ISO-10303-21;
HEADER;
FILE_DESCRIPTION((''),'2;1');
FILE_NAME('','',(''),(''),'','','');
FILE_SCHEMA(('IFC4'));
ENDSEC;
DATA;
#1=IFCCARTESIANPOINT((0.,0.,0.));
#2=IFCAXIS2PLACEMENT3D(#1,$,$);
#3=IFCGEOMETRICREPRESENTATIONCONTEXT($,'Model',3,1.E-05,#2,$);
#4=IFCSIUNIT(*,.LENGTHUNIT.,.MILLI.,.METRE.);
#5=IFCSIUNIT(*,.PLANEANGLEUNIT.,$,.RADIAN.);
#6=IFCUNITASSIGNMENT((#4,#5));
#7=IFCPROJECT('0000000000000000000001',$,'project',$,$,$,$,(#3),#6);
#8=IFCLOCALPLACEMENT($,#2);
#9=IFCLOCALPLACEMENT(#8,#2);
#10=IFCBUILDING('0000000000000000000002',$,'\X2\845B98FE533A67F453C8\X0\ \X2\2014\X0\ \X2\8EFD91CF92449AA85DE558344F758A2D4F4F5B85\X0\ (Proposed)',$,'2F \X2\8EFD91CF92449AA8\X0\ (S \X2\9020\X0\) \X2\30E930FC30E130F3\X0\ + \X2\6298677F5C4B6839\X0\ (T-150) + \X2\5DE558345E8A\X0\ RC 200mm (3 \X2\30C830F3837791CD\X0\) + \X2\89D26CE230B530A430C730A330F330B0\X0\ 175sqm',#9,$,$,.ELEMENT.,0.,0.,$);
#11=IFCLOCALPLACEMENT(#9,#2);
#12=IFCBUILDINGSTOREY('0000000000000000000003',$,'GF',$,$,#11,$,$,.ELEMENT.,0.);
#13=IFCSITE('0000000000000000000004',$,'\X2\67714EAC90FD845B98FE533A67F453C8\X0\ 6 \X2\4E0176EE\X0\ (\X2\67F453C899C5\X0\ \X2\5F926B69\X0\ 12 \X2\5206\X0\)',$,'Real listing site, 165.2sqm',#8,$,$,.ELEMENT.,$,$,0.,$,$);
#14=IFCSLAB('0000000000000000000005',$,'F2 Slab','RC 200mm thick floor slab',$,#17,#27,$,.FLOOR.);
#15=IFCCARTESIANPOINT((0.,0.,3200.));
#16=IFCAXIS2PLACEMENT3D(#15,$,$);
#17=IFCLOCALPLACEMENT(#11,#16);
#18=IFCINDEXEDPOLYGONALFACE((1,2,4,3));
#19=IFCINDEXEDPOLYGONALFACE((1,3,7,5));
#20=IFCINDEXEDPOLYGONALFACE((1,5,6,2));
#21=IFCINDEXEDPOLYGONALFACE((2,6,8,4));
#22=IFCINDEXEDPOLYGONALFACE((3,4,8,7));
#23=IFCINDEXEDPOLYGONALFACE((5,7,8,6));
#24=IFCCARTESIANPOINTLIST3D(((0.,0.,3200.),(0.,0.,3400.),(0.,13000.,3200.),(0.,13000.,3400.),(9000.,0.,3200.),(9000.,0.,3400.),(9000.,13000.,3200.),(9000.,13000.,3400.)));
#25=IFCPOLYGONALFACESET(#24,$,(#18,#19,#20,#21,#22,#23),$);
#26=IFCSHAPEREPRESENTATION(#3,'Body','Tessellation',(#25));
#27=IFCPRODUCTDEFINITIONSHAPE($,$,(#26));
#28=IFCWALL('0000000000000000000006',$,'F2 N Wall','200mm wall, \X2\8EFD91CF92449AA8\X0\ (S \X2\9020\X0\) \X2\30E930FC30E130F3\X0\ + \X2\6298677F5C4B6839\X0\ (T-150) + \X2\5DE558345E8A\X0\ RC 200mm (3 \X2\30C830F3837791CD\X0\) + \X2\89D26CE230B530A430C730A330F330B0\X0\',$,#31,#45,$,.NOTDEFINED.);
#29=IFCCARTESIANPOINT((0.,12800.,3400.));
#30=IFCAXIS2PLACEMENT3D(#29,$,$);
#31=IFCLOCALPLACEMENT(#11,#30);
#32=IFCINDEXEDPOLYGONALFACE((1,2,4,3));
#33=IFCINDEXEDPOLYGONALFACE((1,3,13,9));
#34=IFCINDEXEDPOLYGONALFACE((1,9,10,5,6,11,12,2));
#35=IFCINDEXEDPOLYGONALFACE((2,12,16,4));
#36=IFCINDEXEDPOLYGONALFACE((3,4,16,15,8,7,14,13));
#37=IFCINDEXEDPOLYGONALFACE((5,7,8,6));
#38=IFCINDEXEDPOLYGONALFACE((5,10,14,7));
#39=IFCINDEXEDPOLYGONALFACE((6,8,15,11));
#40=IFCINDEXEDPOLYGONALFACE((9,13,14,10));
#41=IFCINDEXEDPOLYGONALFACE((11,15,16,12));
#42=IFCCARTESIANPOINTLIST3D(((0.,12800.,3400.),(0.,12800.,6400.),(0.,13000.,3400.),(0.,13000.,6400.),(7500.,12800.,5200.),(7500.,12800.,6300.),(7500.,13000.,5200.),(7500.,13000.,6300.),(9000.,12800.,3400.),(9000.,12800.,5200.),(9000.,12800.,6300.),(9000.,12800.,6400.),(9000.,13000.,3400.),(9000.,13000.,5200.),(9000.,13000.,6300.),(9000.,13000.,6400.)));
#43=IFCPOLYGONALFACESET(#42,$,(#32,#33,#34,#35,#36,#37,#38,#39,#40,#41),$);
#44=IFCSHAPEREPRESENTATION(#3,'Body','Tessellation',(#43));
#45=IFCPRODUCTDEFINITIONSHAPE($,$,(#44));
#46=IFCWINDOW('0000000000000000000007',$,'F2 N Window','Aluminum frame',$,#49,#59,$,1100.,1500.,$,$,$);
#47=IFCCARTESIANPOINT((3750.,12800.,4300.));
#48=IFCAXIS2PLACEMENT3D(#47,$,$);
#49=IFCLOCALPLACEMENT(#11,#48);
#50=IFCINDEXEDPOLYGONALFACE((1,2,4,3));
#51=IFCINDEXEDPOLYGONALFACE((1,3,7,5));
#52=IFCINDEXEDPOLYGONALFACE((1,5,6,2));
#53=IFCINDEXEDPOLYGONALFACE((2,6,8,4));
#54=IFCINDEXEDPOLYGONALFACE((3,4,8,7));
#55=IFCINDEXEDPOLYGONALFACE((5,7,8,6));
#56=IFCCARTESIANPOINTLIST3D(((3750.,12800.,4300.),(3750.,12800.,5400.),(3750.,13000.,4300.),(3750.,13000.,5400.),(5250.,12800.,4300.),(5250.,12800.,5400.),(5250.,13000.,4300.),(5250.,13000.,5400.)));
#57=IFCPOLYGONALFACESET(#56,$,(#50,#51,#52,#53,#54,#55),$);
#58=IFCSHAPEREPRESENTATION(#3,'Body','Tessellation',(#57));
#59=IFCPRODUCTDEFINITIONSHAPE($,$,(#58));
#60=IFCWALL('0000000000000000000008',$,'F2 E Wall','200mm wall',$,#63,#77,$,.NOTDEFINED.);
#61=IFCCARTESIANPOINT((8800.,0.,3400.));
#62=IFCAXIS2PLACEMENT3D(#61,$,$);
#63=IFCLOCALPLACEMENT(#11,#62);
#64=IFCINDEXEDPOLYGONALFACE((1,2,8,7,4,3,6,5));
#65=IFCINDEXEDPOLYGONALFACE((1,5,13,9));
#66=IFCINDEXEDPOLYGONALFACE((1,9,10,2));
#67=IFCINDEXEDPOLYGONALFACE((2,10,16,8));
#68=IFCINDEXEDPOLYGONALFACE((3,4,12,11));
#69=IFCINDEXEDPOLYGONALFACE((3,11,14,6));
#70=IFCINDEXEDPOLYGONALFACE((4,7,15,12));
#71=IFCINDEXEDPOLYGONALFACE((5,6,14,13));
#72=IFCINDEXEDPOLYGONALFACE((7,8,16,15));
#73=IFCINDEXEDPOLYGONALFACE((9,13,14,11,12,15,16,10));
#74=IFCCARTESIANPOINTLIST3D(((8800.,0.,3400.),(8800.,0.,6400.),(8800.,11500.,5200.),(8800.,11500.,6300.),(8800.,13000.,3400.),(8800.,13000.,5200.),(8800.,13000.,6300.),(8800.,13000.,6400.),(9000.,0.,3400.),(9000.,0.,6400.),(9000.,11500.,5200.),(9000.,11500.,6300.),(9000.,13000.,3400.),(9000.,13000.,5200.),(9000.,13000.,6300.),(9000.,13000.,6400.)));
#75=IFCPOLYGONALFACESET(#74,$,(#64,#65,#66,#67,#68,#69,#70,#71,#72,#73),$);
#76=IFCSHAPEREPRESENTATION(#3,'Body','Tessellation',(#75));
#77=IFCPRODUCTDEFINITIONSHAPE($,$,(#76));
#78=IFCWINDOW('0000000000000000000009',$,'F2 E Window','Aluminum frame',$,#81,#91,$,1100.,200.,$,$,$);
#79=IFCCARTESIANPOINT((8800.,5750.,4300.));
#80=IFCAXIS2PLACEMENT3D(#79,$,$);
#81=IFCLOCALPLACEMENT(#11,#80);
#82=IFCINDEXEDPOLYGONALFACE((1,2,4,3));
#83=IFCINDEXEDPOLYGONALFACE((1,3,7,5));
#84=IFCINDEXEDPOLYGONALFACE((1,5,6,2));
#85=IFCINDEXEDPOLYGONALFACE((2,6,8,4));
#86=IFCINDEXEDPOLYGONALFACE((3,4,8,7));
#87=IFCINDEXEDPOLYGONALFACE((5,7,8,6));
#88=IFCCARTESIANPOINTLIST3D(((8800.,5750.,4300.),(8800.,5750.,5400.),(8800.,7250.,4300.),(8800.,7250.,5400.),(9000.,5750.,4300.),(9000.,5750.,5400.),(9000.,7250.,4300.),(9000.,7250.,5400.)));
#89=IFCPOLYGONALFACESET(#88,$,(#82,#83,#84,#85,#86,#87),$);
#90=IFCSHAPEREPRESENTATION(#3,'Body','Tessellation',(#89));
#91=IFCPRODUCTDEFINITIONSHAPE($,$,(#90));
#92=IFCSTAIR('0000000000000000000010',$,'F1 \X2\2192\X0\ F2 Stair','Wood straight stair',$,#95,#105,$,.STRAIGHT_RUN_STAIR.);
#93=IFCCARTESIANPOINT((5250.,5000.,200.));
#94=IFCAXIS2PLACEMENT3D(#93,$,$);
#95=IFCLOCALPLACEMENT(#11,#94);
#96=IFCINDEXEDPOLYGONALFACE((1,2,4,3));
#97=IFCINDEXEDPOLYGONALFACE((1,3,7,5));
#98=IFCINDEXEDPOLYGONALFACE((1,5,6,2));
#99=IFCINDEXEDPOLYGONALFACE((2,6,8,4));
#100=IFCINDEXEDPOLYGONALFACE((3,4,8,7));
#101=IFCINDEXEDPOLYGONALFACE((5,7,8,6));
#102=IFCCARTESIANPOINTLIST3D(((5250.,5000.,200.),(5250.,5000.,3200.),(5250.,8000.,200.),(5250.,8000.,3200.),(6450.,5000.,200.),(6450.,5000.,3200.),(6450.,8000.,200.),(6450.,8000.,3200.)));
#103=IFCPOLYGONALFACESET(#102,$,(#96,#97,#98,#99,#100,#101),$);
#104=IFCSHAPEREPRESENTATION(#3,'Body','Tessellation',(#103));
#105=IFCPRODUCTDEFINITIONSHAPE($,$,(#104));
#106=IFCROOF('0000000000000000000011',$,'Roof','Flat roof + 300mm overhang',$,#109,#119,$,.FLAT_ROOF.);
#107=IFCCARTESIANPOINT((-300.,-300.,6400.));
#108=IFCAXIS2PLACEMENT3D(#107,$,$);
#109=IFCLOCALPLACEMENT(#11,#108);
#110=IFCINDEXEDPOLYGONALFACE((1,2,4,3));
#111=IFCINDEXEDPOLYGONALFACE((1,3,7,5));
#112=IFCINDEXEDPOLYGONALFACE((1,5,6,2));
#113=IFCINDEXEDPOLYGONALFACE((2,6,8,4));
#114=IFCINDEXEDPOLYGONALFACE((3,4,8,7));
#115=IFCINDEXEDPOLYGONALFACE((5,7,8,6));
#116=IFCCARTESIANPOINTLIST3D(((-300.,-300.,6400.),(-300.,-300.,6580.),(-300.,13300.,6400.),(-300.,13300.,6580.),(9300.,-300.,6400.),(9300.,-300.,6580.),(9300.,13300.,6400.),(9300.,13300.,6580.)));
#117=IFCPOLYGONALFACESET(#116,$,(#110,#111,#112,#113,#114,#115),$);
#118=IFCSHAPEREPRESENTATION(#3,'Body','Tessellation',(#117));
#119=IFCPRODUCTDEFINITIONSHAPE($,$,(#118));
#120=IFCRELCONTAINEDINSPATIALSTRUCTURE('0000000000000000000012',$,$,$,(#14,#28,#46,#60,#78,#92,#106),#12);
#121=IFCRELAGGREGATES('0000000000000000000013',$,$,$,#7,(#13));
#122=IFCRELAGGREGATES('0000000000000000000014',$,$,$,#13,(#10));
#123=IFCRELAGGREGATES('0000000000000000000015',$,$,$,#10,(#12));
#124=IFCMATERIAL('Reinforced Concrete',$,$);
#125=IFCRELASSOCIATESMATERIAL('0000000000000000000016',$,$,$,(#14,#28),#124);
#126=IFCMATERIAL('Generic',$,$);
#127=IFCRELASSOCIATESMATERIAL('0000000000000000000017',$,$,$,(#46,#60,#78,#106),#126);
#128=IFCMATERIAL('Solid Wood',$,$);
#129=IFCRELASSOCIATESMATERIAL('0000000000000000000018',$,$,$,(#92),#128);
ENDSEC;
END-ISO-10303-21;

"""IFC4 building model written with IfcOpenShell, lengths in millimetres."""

from ifc_helpers import new_model, si_unit, frame, frame_2d, origin, place, context, project, spatial, rectangle, extrude, material, element, fill, save


model = new_model("IFC4")

# Units and contexts
model_context = context("Model", 3, precision=1e-05, world=origin())
ifc_project = project(units=[si_unit("LENGTHUNIT", "METRE", prefix="MILLI"), si_unit("PLANEANGLEUNIT", "RADIAN")], contexts=[model_context])

# Site, building, storey
site_placement = place(None, origin())
site = spatial("IfcSite", under=ifc_project, at=site_placement, Name="東京都葛飾区柴又 6 丁目 (柴又駅 徒歩 12 分)", ObjectType="Real listing site, 165.2sqm", CompositionType="ELEMENT", RefElevation=0.0)
building_placement = place(site_placement, origin())
building = spatial("IfcBuilding", under=site, at=building_placement, Name="葛飾区柴又 — 軽量鉄骨工場併設住宅 (Proposed)", ObjectType="2F 軽量鉄骨 (S 造) ラーメン + 折板屋根 (T-150) + 工場床 RC 200mm (3 トン荷重) + 角波サイディング 175sqm", CompositionType="ELEMENT", ElevationOfRefHeight=0.0, ElevationOfTerrain=0.0)
storey_placement = place(building_placement, origin())
storey = spatial("IfcBuildingStorey", under=building, at=storey_placement, Name="GF", CompositionType="ELEMENT", Elevation=0.0)

# Slab
ifc_material_1 = material(Name="Reinforced Concrete")
slab_1_placement = place(storey_placement, frame((0.0, 0.0, 3200.0)))
element("IfcSlab", 1, at=slab_1_placement, inside=storey, material=ifc_material_1, Name="F2 Slab", Description="RC 200mm thick floor slab", PredefinedType="FLOOR", context=model_context, shape_type="SweptSolid", body=[
    extrude(rectangle(XDim=9000.0, YDim=13000.0, at=frame_2d((4500.0, 6500.0))), frame((0.0, 0.0, 3200.0)), (0.0, 0.0, 1.0), 200.0),
])

# Shared definitions
ifc_material_2 = material(Name="Generic")

# Shared definitions
ifc_material_3 = material(Name="Solid Wood")

# Walls, openings, windows
wall_1_placement = place(storey_placement, frame((0.0, 12800.0, 3400.0)))
wall_1 = element("IfcWall", 2, at=wall_1_placement, inside=storey, material=ifc_material_1, Name="F2 N Wall", Description="200mm wall, 軽量鉄骨 (S 造) ラーメン + 折板屋根 (T-150) + 工場床 RC 200mm (3 トン荷重) + 角波サイディング", PredefinedType="NOTDEFINED", context=model_context, shape_type="SweptSolid", body=[
    extrude(rectangle(XDim=9000.0, YDim=200.0, at=frame_2d((4500.0, 100.0))), frame((0.0, 12800.0, 3400.0)), (0.0, 0.0, 1.0), 3000.0),
])
opening_1_placement = place(storey_placement, frame((3750.0, 12800.0, 4300.0)))
opening_1 = element("IfcOpeningElement", 3, at=opening_1_placement, cuts=wall_1, PredefinedType="NOTDEFINED", context=model_context, shape_type="SweptSolid", body=[
    extrude(rectangle(XDim=1500.0, YDim=200.0, at=frame_2d((750.0, 100.0))), frame((3750.0, 12800.0, 4300.0)), (0.0, 0.0, 1.0), 1100.0),
])
window_1_placement = place(storey_placement, frame((3750.0, 12800.0, 4300.0)))
window_1 = element("IfcWindow", 4, at=window_1_placement, inside=storey, material=ifc_material_2, Name="F2 N Window", Description="Aluminum frame", OverallHeight=1100.0, OverallWidth=1500.0, context=model_context, shape_type="SweptSolid", body=[
    extrude(rectangle(XDim=1500.0, YDim=200.0, at=frame_2d((750.0, 100.0))), frame((3750.0, 12800.0, 4300.0)), (0.0, 0.0, 1.0), 1100.0),
])
fill(opening_1, window_1)
wall_2_placement = place(storey_placement, frame((8800.0, 0.0, 3400.0)))
wall_2 = element("IfcWall", 5, at=wall_2_placement, inside=storey, material=ifc_material_2, Name="F2 E Wall", Description="200mm wall", PredefinedType="NOTDEFINED", context=model_context, shape_type="SweptSolid", body=[
    extrude(rectangle(XDim=200.0, YDim=13000.0, at=frame_2d((100.0, 6500.0))), frame((8800.0, 0.0, 3400.0)), (0.0, 0.0, 1.0), 3000.0),
])
opening_2_placement = place(storey_placement, frame((8800.0, 5750.0, 4300.0)))
opening_2 = element("IfcOpeningElement", 6, at=opening_2_placement, cuts=wall_2, PredefinedType="NOTDEFINED", context=model_context, shape_type="SweptSolid", body=[
    extrude(rectangle(XDim=200.0, YDim=1500.0, at=frame_2d((100.0, 750.0))), frame((8800.0, 5750.0, 4300.0)), (0.0, 0.0, 1.0), 1100.0),
])
window_2_placement = place(storey_placement, frame((8800.0, 5750.0, 4300.0)))
window_2 = element("IfcWindow", 7, at=window_2_placement, inside=storey, material=ifc_material_2, Name="F2 E Window", Description="Aluminum frame", OverallHeight=1100.0, OverallWidth=200.0, context=model_context, shape_type="SweptSolid", body=[
    extrude(rectangle(XDim=200.0, YDim=1500.0, at=frame_2d((100.0, 750.0))), frame((8800.0, 5750.0, 4300.0)), (0.0, 0.0, 1.0), 1100.0),
])
fill(opening_2, window_2)

# Stair
stair_placement = place(storey_placement, frame((5250.0, 5000.0, 200.0)))
element("IfcStair", 8, at=stair_placement, inside=storey, material=ifc_material_3, Name="F1 → F2 Stair", Description="Wood straight stair", PredefinedType="STRAIGHT_RUN_STAIR", context=model_context, shape_type="SweptSolid", body=[
    extrude(rectangle(XDim=1200.0, YDim=3000.0, at=frame_2d((600.0, 1500.0))), frame((5250.0, 5000.0, 200.0)), (0.0, 0.0, 1.0), 3000.0),
])

# Roof
roof_placement = place(storey_placement, frame((-300.0, -300.0, 6400.0)))
element("IfcRoof", 9, at=roof_placement, inside=storey, material=ifc_material_2, Name="Roof", Description="Flat roof + 300mm overhang", PredefinedType="FLAT_ROOF", context=model_context, shape_type="SweptSolid", body=[
    extrude(rectangle(XDim=9600.0, YDim=13600.0, at=frame_2d((4800.0, 6800.0))), frame((-300.0, -300.0, 6400.0)), (0.0, 0.0, 1.0), 180.0),
])

save(model, "model.ifc")
